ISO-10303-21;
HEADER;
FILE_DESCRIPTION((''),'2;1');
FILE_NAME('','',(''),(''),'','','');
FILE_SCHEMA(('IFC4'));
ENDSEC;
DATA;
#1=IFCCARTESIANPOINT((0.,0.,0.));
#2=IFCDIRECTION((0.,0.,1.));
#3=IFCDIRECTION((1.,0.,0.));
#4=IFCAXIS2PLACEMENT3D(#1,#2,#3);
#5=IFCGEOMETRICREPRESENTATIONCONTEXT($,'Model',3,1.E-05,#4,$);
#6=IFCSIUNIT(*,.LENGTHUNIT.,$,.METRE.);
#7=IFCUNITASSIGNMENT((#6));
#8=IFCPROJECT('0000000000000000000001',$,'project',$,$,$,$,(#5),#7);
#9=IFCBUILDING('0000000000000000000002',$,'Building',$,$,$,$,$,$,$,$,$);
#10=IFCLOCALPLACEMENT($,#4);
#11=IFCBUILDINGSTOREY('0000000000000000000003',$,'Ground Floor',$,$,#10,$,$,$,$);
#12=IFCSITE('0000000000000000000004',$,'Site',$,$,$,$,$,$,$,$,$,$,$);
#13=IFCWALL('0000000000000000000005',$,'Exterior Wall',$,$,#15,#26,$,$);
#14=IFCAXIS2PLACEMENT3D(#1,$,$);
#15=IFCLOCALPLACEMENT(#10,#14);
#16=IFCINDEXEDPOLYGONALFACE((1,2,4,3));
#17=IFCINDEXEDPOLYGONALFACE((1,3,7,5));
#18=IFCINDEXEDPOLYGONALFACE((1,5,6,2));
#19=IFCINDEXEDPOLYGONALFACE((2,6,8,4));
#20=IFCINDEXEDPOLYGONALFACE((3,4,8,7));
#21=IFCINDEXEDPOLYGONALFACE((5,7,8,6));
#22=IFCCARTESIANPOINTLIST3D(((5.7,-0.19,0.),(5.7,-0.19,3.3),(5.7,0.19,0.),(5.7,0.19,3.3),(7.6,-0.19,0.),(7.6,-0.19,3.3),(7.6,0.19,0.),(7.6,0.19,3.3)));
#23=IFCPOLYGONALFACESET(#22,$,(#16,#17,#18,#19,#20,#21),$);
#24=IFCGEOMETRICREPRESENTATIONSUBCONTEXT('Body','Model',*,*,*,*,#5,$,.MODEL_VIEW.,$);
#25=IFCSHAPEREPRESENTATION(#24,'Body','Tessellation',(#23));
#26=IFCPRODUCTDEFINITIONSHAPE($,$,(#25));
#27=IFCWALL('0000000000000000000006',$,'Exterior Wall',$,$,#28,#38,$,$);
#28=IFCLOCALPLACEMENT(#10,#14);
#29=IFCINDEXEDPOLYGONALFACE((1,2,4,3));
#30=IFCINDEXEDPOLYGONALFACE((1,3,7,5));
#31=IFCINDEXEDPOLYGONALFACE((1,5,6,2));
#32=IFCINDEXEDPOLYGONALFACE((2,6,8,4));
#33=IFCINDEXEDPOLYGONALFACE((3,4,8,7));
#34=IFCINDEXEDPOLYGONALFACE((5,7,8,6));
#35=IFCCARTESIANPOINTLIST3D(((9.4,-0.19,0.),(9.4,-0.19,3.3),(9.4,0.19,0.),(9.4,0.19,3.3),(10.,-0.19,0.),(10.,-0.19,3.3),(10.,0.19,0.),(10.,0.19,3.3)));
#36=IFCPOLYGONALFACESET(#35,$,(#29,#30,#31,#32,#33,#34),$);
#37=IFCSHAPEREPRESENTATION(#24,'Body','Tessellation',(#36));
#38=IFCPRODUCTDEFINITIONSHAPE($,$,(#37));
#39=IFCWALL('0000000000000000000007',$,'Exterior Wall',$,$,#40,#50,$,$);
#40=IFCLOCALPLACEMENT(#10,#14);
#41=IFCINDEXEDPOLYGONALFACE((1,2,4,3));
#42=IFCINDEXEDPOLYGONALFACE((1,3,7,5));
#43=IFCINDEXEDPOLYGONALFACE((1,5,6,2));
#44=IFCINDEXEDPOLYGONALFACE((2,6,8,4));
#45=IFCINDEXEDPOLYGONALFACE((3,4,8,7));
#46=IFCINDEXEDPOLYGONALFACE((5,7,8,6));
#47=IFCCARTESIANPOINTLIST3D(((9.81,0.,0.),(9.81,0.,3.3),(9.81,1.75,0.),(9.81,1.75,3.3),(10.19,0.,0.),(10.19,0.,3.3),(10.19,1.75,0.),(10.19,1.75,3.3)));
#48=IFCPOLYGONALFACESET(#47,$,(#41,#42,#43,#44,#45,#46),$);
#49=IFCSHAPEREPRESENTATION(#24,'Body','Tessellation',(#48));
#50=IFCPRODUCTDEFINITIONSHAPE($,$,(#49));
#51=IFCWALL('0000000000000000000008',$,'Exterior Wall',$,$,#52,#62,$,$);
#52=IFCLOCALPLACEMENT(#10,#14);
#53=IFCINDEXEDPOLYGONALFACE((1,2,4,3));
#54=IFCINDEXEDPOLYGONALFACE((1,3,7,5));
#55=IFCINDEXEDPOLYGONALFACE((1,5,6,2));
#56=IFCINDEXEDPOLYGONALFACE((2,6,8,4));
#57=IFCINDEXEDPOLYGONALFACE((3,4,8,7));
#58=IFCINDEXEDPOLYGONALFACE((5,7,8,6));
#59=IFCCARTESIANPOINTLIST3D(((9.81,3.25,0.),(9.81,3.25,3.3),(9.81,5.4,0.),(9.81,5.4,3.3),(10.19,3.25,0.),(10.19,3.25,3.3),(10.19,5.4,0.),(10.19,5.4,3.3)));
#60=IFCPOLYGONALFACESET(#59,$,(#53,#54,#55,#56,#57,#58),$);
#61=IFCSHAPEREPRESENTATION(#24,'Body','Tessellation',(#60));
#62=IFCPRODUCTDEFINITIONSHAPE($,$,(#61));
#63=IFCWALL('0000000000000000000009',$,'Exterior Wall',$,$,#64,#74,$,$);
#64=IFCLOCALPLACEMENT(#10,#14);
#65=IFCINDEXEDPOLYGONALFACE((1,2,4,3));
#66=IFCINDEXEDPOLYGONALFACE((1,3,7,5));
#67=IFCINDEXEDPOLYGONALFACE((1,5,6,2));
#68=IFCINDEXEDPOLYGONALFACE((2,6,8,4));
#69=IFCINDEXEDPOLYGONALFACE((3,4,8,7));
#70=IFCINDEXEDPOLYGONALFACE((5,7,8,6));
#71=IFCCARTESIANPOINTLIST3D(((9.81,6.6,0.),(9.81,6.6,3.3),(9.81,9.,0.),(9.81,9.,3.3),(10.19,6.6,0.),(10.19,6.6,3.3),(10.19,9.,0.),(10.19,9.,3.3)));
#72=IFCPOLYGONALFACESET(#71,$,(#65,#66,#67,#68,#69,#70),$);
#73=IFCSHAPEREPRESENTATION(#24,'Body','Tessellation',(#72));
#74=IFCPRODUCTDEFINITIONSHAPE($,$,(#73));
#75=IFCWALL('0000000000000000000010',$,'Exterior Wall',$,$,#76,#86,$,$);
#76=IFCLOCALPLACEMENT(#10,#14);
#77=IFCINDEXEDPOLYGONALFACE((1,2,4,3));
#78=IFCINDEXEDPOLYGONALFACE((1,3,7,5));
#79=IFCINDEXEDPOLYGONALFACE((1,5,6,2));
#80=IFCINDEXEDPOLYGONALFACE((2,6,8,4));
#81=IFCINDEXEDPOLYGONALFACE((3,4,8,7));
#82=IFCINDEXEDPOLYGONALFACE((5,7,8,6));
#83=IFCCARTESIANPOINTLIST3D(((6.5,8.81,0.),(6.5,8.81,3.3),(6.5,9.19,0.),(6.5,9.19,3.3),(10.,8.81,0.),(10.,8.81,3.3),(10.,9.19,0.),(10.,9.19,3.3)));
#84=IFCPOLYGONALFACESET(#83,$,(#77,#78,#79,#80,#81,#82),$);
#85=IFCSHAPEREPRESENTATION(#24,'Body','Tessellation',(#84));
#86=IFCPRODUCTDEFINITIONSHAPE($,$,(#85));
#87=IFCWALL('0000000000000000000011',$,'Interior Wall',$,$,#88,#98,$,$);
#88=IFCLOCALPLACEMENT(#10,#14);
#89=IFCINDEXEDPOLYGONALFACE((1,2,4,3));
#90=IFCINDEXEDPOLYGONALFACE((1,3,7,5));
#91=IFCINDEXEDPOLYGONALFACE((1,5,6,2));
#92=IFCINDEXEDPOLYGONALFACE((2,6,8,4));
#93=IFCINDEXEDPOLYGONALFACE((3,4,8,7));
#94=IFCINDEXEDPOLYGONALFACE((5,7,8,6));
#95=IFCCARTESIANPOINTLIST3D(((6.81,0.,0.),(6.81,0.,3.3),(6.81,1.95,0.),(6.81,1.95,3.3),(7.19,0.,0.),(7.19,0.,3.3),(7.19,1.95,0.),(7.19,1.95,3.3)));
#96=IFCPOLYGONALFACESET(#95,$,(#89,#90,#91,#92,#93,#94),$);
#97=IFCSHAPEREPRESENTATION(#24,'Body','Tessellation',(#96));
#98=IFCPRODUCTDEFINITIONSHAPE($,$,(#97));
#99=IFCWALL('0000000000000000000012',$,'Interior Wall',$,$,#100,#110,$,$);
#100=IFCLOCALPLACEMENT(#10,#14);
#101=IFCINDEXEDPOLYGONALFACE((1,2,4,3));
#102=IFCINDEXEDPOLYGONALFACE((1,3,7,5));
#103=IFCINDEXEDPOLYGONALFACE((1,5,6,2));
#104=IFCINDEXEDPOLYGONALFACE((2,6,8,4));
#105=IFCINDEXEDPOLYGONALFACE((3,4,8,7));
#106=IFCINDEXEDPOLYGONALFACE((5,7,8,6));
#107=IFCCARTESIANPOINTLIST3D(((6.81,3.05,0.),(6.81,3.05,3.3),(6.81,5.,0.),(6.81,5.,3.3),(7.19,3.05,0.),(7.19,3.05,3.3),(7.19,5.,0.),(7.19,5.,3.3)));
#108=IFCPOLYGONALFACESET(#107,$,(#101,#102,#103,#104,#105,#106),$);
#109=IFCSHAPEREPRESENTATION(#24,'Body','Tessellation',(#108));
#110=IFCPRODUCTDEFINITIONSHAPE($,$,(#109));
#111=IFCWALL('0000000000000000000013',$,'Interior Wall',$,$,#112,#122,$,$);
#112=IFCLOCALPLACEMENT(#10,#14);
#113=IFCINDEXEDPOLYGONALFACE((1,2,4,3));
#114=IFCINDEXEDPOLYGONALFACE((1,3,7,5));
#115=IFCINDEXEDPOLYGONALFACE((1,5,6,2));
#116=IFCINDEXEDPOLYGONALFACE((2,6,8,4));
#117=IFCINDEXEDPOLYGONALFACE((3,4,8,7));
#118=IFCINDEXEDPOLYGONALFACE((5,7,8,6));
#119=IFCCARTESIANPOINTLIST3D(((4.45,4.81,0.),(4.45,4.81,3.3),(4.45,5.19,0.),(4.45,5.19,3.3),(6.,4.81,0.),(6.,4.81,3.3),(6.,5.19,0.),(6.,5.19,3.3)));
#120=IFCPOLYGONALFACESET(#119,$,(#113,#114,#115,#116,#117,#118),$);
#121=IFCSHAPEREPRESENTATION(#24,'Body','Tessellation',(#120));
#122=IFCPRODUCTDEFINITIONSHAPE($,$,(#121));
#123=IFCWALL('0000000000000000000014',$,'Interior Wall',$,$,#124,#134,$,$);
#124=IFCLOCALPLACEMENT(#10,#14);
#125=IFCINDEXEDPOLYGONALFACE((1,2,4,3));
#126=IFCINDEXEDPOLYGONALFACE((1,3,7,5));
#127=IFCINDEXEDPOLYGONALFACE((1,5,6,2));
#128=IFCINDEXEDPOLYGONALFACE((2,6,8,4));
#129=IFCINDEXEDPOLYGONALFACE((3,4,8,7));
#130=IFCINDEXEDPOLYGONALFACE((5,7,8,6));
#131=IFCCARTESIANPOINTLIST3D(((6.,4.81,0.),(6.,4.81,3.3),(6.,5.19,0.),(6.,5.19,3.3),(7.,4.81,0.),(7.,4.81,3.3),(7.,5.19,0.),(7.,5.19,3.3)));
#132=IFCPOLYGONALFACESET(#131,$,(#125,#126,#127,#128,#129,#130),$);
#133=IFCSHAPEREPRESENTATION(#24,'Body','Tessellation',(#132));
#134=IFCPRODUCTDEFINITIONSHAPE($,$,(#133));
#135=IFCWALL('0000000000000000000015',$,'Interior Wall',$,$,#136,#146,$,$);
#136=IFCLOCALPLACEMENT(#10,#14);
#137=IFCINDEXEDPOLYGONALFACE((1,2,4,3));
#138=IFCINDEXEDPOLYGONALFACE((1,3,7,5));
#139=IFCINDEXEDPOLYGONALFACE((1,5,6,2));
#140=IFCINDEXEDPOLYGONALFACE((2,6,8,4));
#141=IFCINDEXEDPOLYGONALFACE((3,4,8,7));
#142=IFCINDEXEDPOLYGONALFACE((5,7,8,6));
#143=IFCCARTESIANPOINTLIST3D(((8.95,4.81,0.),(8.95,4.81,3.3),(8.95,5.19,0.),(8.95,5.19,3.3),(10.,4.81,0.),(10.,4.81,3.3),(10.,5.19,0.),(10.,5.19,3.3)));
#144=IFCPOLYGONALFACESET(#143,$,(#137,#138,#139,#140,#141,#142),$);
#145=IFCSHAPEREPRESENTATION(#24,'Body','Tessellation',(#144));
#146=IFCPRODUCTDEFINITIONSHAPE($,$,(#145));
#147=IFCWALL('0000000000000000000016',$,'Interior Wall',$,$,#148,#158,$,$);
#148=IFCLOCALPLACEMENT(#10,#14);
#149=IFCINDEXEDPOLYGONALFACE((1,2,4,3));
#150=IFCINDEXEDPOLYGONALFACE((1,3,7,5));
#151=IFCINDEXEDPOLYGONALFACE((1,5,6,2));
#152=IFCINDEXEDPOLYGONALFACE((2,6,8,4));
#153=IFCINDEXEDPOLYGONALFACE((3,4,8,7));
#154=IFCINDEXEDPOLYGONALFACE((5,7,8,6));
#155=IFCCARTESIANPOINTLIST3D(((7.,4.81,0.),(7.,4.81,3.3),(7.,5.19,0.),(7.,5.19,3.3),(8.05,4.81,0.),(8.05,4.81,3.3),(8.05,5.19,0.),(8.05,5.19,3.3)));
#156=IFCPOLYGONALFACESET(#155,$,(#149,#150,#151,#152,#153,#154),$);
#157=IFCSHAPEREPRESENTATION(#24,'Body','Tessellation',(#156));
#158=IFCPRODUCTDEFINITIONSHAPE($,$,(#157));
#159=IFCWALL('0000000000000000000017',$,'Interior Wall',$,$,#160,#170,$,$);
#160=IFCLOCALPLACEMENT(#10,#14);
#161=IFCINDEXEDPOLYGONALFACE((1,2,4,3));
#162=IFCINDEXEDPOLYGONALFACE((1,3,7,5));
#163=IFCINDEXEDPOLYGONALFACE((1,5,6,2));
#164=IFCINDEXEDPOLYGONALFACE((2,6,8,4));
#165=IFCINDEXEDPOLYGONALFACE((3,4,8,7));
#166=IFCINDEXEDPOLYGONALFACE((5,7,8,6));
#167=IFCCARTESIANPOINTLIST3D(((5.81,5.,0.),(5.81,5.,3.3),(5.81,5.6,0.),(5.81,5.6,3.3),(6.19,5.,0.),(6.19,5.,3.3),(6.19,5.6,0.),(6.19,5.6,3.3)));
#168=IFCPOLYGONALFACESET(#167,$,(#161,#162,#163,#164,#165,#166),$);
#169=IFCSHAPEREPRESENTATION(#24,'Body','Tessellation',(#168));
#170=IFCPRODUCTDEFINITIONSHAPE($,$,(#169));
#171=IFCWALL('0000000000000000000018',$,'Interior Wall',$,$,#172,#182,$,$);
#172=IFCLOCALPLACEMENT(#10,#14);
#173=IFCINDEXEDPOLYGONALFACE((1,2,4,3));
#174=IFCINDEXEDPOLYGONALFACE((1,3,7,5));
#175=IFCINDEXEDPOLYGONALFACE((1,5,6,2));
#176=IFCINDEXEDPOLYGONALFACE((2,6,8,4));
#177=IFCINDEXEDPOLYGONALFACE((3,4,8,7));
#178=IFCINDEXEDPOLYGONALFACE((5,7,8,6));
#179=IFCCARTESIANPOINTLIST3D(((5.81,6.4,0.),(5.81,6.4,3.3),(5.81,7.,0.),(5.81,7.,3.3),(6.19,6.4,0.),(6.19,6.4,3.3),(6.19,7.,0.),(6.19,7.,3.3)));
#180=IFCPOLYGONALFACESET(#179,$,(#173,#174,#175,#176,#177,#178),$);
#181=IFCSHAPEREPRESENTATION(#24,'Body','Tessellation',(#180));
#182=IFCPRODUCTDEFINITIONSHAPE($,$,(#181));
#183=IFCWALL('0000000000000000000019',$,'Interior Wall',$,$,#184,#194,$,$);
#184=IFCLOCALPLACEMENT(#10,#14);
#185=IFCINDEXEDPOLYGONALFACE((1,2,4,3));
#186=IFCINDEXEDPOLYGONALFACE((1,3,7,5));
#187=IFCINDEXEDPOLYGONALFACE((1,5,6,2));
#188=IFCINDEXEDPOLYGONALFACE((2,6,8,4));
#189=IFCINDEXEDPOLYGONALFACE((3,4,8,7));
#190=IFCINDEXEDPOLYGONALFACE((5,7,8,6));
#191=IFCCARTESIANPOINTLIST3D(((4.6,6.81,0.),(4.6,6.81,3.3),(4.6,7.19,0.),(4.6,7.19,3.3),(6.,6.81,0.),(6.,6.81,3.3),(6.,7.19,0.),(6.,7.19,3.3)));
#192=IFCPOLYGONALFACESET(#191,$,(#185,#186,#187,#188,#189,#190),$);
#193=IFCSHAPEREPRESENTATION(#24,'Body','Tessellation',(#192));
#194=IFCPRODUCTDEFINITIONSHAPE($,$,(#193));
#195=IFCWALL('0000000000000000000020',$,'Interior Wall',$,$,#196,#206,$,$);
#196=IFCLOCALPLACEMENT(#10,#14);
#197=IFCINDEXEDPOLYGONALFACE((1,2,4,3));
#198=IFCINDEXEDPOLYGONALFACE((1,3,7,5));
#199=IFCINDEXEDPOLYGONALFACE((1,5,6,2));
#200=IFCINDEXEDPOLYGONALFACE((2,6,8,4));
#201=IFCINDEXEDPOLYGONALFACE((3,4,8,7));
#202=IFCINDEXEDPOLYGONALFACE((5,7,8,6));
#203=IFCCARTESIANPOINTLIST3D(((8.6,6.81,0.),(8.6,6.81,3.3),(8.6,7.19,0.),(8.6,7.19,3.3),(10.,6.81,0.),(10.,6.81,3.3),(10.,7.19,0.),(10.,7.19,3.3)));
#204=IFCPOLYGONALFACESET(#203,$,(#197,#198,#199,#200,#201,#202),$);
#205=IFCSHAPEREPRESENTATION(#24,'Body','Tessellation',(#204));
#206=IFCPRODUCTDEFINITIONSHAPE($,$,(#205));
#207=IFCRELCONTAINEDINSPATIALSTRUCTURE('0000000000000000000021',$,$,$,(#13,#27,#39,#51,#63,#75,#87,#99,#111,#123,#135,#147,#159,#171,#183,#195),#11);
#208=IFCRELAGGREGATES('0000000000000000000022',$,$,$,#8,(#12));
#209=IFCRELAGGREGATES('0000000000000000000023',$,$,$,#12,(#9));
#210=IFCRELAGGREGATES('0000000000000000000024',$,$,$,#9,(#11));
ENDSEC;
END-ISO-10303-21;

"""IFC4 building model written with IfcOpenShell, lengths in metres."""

from ifc_helpers import new_model, si_unit, frame, origin_with_axes, place, context, subcontext, project, spatial, indexed_curve, outline, extrude, element, save


model = new_model("IFC4")

# Units and contexts
model_context = context("Model", 3, precision=1e-05, world=origin_with_axes())
body_context = subcontext(model_context, "Body", "Model", "MODEL_VIEW")
ifc_project = project(units=[si_unit("LENGTHUNIT", "METRE")], contexts=[model_context])

# Site, building, storey
site = spatial("IfcSite", under=ifc_project, Name="Site")
building = spatial("IfcBuilding", under=site, Name="Building")
storey_placement = place(None, origin_with_axes())
storey = spatial("IfcBuildingStorey", under=building, at=storey_placement, Name="Ground Floor")

# Walls
wall_1_placement = place(storey_placement, frame((5.7, 0.0, 0.0), z_axis=(0.0, 0.0, 1.0), x_axis=(1.0, 0.0, 0.0)))
element("IfcWall", 1, at=wall_1_placement, inside=storey, Name="Exterior Wall", context=body_context, shape_type="SweptSolid", body=[
    extrude(outline(indexed_curve([(0.0, 0.0), (0.0, 0.38), (1.9, 0.38), (1.9, 0.0), (0.0, 0.0)], self_intersect=False)), frame((0.0, -0.19, 0.0), z_axis=(0.0, 0.0, 1.0), x_axis=(1.0, 0.0, 0.0)), (0.0, 0.0, 1.0), 3.3),
])
wall_2_placement = place(storey_placement, frame((9.4, 0.0, 0.0), z_axis=(0.0, 0.0, 1.0), x_axis=(1.0, 0.0, 0.0)))
element("IfcWall", 2, at=wall_2_placement, inside=storey, Name="Exterior Wall", context=body_context, shape_type="SweptSolid", body=[
    extrude(outline(indexed_curve([(0.0, 0.0), (0.0, 0.38), (0.6, 0.38), (0.6, 0.0), (0.0, 0.0)], self_intersect=False)), frame((0.0, -0.19, 0.0), z_axis=(0.0, 0.0, 1.0), x_axis=(1.0, 0.0, 0.0)), (0.0, 0.0, 1.0), 3.3),
])
wall_3_placement = place(storey_placement, frame((10.0, 0.0, 0.0), z_axis=(0.0, 0.0, 1.0), x_axis=(0.0, 1.0, 0.0)))
element("IfcWall", 3, at=wall_3_placement, inside=storey, Name="Exterior Wall", context=body_context, shape_type="SweptSolid", body=[
    extrude(outline(indexed_curve([(0.0, 0.0), (0.0, 0.38), (1.75, 0.38), (1.75, 0.0), (0.0, 0.0)], self_intersect=False)), frame((0.0, -0.19, 0.0), z_axis=(0.0, 0.0, 1.0), x_axis=(1.0, 0.0, 0.0)), (0.0, 0.0, 1.0), 3.3),
])
wall_4_placement = place(storey_placement, frame((10.0, 3.25, 0.0), z_axis=(0.0, 0.0, 1.0), x_axis=(0.0, 1.0, 0.0)))
element("IfcWall", 4, at=wall_4_placement, inside=storey, Name="Exterior Wall", context=body_context, shape_type="SweptSolid", body=[
    extrude(outline(indexed_curve([(0.0, 0.0), (0.0, 0.38), (2.15, 0.38), (2.15, 0.0), (0.0, 0.0)], self_intersect=False)), frame((0.0, -0.19, 0.0), z_axis=(0.0, 0.0, 1.0), x_axis=(1.0, 0.0, 0.0)), (0.0, 0.0, 1.0), 3.3),
])
wall_5_placement = place(storey_placement, frame((10.0, 6.6, 0.0), z_axis=(0.0, 0.0, 1.0), x_axis=(0.0, 1.0, 0.0)))
element("IfcWall", 5, at=wall_5_placement, inside=storey, Name="Exterior Wall", context=body_context, shape_type="SweptSolid", body=[
    extrude(outline(indexed_curve([(0.0, 0.0), (0.0, 0.38), (2.4, 0.38), (2.4, 0.0), (0.0, 0.0)], self_intersect=False)), frame((0.0, -0.19, 0.0), z_axis=(0.0, 0.0, 1.0), x_axis=(1.0, 0.0, 0.0)), (0.0, 0.0, 1.0), 3.3),
])
wall_6_placement = place(storey_placement, frame((10.0, 9.0, 0.0), z_axis=(0.0, 0.0, 1.0), x_axis=(-1.0, 0.0, 0.0)))
element("IfcWall", 6, at=wall_6_placement, inside=storey, Name="Exterior Wall", context=body_context, shape_type="SweptSolid", body=[
    extrude(outline(indexed_curve([(0.0, 0.0), (0.0, 0.38), (3.5, 0.38), (3.5, 0.0), (0.0, 0.0)], self_intersect=False)), frame((0.0, -0.19, 0.0), z_axis=(0.0, 0.0, 1.0), x_axis=(1.0, 0.0, 0.0)), (0.0, 0.0, 1.0), 3.3),
])
wall_7_placement = place(storey_placement, frame((7.0, 0.0, 0.0), z_axis=(0.0, 0.0, 1.0), x_axis=(0.0, 1.0, 0.0)))
element("IfcWall", 7, at=wall_7_placement, inside=storey, Name="Interior Wall", context=body_context, shape_type="SweptSolid", body=[
    extrude(outline(indexed_curve([(0.0, 0.0), (0.0, 0.38), (1.95, 0.38), (1.95, 0.0), (0.0, 0.0)], self_intersect=False)), frame((0.0, -0.19, 0.0), z_axis=(0.0, 0.0, 1.0), x_axis=(1.0, 0.0, 0.0)), (0.0, 0.0, 1.0), 3.3),
])
wall_8_placement = place(storey_placement, frame((7.0, 3.05, 0.0), z_axis=(0.0, 0.0, 1.0), x_axis=(0.0, 1.0, 0.0)))
element("IfcWall", 8, at=wall_8_placement, inside=storey, Name="Interior Wall", context=body_context, shape_type="SweptSolid", body=[
    extrude(outline(indexed_curve([(0.0, 0.0), (0.0, 0.38), (1.95, 0.38), (1.95, 0.0), (0.0, 0.0)], self_intersect=False)), frame((0.0, -0.19, 0.0), z_axis=(0.0, 0.0, 1.0), x_axis=(1.0, 0.0, 0.0)), (0.0, 0.0, 1.0), 3.3),
])
wall_9_placement = place(storey_placement, frame((6.0, 5.0, 0.0), z_axis=(0.0, 0.0, 1.0), x_axis=(-1.0, 0.0, 0.0)))
element("IfcWall", 9, at=wall_9_placement, inside=storey, Name="Interior Wall", context=body_context, shape_type="SweptSolid", body=[
    extrude(outline(indexed_curve([(0.0, 0.0), (0.0, 0.38), (1.55, 0.38), (1.55, 0.0), (0.0, 0.0)], self_intersect=False)), frame((0.0, -0.19, 0.0), z_axis=(0.0, 0.0, 1.0), x_axis=(1.0, 0.0, 0.0)), (0.0, 0.0, 1.0), 3.3),
])
wall_10_placement = place(storey_placement, frame((7.0, 5.0, 0.0), z_axis=(0.0, 0.0, 1.0), x_axis=(-1.0, 0.0, 0.0)))
element("IfcWall", 10, at=wall_10_placement, inside=storey, Name="Interior Wall", context=body_context, shape_type="SweptSolid", body=[
    extrude(outline(indexed_curve([(0.0, 0.0), (0.0, 0.38), (1.0, 0.38), (1.0, 0.0), (0.0, 0.0)], self_intersect=False)), frame((0.0, -0.19, 0.0), z_axis=(0.0, 0.0, 1.0), x_axis=(1.0, 0.0, 0.0)), (0.0, 0.0, 1.0), 3.3),
])
for number, where, z_axis, x_axis, name in (
    (11, (10.0, 5.0, 0.0), (0.0, 0.0, 1.0), (-1.0, 0.0, 0.0), "Interior Wall"),
    (12, (8.05, 5.0, 0.0), (0.0, 0.0, 1.0), (-1.0, 0.0, 0.0), "Interior Wall"),
):
    element("IfcWall", number, at=place(storey_placement, frame(where, z_axis=z_axis, x_axis=x_axis)), inside=storey, Name=name, context=body_context, shape_type="SweptSolid", body=[
        extrude(outline(indexed_curve([(0.0, 0.0), (0.0, 0.38), (1.05, 0.38), (1.05, 0.0), (0.0, 0.0)], self_intersect=False)), frame((0.0, -0.19, 0.0), z_axis=(0.0, 0.0, 1.0), x_axis=(1.0, 0.0, 0.0)), (0.0, 0.0, 1.0), 3.3),
    ])
for number, where, z_axis, x_axis, name in (
    (13, (6.0, 5.0, 0.0), (0.0, 0.0, 1.0), (0.0, 1.0, 0.0), "Interior Wall"),
    (14, (6.0, 6.4, 0.0), (0.0, 0.0, 1.0), (0.0, 1.0, 0.0), "Interior Wall"),
):
    element("IfcWall", number, at=place(storey_placement, frame(where, z_axis=z_axis, x_axis=x_axis)), inside=storey, Name=name, context=body_context, shape_type="SweptSolid", body=[
        extrude(outline(indexed_curve([(0.0, 0.0), (0.0, 0.38), (0.6, 0.38), (0.6, 0.0), (0.0, 0.0)], self_intersect=False)), frame((0.0, -0.19, 0.0), z_axis=(0.0, 0.0, 1.0), x_axis=(1.0, 0.0, 0.0)), (0.0, 0.0, 1.0), 3.3),
    ])
for number, where, z_axis, x_axis, name in (
    (15, (6.0, 7.0, 0.0), (0.0, 0.0, 1.0), (-1.0, 0.0, 0.0), "Interior Wall"),
    (16, (10.0, 7.0, 0.0), (0.0, 0.0, 1.0), (-1.0, 0.0, 0.0), "Interior Wall"),
):
    element("IfcWall", number, at=place(storey_placement, frame(where, z_axis=z_axis, x_axis=x_axis)), inside=storey, Name=name, context=body_context, shape_type="SweptSolid", body=[
        extrude(outline(indexed_curve([(0.0, 0.0), (0.0, 0.38), (1.4, 0.38), (1.4, 0.0), (0.0, 0.0)], self_intersect=False)), frame((0.0, -0.19, 0.0), z_axis=(0.0, 0.0, 1.0), x_axis=(1.0, 0.0, 0.0)), (0.0, 0.0, 1.0), 3.3),
    ])

save(model, "model.ifc")
